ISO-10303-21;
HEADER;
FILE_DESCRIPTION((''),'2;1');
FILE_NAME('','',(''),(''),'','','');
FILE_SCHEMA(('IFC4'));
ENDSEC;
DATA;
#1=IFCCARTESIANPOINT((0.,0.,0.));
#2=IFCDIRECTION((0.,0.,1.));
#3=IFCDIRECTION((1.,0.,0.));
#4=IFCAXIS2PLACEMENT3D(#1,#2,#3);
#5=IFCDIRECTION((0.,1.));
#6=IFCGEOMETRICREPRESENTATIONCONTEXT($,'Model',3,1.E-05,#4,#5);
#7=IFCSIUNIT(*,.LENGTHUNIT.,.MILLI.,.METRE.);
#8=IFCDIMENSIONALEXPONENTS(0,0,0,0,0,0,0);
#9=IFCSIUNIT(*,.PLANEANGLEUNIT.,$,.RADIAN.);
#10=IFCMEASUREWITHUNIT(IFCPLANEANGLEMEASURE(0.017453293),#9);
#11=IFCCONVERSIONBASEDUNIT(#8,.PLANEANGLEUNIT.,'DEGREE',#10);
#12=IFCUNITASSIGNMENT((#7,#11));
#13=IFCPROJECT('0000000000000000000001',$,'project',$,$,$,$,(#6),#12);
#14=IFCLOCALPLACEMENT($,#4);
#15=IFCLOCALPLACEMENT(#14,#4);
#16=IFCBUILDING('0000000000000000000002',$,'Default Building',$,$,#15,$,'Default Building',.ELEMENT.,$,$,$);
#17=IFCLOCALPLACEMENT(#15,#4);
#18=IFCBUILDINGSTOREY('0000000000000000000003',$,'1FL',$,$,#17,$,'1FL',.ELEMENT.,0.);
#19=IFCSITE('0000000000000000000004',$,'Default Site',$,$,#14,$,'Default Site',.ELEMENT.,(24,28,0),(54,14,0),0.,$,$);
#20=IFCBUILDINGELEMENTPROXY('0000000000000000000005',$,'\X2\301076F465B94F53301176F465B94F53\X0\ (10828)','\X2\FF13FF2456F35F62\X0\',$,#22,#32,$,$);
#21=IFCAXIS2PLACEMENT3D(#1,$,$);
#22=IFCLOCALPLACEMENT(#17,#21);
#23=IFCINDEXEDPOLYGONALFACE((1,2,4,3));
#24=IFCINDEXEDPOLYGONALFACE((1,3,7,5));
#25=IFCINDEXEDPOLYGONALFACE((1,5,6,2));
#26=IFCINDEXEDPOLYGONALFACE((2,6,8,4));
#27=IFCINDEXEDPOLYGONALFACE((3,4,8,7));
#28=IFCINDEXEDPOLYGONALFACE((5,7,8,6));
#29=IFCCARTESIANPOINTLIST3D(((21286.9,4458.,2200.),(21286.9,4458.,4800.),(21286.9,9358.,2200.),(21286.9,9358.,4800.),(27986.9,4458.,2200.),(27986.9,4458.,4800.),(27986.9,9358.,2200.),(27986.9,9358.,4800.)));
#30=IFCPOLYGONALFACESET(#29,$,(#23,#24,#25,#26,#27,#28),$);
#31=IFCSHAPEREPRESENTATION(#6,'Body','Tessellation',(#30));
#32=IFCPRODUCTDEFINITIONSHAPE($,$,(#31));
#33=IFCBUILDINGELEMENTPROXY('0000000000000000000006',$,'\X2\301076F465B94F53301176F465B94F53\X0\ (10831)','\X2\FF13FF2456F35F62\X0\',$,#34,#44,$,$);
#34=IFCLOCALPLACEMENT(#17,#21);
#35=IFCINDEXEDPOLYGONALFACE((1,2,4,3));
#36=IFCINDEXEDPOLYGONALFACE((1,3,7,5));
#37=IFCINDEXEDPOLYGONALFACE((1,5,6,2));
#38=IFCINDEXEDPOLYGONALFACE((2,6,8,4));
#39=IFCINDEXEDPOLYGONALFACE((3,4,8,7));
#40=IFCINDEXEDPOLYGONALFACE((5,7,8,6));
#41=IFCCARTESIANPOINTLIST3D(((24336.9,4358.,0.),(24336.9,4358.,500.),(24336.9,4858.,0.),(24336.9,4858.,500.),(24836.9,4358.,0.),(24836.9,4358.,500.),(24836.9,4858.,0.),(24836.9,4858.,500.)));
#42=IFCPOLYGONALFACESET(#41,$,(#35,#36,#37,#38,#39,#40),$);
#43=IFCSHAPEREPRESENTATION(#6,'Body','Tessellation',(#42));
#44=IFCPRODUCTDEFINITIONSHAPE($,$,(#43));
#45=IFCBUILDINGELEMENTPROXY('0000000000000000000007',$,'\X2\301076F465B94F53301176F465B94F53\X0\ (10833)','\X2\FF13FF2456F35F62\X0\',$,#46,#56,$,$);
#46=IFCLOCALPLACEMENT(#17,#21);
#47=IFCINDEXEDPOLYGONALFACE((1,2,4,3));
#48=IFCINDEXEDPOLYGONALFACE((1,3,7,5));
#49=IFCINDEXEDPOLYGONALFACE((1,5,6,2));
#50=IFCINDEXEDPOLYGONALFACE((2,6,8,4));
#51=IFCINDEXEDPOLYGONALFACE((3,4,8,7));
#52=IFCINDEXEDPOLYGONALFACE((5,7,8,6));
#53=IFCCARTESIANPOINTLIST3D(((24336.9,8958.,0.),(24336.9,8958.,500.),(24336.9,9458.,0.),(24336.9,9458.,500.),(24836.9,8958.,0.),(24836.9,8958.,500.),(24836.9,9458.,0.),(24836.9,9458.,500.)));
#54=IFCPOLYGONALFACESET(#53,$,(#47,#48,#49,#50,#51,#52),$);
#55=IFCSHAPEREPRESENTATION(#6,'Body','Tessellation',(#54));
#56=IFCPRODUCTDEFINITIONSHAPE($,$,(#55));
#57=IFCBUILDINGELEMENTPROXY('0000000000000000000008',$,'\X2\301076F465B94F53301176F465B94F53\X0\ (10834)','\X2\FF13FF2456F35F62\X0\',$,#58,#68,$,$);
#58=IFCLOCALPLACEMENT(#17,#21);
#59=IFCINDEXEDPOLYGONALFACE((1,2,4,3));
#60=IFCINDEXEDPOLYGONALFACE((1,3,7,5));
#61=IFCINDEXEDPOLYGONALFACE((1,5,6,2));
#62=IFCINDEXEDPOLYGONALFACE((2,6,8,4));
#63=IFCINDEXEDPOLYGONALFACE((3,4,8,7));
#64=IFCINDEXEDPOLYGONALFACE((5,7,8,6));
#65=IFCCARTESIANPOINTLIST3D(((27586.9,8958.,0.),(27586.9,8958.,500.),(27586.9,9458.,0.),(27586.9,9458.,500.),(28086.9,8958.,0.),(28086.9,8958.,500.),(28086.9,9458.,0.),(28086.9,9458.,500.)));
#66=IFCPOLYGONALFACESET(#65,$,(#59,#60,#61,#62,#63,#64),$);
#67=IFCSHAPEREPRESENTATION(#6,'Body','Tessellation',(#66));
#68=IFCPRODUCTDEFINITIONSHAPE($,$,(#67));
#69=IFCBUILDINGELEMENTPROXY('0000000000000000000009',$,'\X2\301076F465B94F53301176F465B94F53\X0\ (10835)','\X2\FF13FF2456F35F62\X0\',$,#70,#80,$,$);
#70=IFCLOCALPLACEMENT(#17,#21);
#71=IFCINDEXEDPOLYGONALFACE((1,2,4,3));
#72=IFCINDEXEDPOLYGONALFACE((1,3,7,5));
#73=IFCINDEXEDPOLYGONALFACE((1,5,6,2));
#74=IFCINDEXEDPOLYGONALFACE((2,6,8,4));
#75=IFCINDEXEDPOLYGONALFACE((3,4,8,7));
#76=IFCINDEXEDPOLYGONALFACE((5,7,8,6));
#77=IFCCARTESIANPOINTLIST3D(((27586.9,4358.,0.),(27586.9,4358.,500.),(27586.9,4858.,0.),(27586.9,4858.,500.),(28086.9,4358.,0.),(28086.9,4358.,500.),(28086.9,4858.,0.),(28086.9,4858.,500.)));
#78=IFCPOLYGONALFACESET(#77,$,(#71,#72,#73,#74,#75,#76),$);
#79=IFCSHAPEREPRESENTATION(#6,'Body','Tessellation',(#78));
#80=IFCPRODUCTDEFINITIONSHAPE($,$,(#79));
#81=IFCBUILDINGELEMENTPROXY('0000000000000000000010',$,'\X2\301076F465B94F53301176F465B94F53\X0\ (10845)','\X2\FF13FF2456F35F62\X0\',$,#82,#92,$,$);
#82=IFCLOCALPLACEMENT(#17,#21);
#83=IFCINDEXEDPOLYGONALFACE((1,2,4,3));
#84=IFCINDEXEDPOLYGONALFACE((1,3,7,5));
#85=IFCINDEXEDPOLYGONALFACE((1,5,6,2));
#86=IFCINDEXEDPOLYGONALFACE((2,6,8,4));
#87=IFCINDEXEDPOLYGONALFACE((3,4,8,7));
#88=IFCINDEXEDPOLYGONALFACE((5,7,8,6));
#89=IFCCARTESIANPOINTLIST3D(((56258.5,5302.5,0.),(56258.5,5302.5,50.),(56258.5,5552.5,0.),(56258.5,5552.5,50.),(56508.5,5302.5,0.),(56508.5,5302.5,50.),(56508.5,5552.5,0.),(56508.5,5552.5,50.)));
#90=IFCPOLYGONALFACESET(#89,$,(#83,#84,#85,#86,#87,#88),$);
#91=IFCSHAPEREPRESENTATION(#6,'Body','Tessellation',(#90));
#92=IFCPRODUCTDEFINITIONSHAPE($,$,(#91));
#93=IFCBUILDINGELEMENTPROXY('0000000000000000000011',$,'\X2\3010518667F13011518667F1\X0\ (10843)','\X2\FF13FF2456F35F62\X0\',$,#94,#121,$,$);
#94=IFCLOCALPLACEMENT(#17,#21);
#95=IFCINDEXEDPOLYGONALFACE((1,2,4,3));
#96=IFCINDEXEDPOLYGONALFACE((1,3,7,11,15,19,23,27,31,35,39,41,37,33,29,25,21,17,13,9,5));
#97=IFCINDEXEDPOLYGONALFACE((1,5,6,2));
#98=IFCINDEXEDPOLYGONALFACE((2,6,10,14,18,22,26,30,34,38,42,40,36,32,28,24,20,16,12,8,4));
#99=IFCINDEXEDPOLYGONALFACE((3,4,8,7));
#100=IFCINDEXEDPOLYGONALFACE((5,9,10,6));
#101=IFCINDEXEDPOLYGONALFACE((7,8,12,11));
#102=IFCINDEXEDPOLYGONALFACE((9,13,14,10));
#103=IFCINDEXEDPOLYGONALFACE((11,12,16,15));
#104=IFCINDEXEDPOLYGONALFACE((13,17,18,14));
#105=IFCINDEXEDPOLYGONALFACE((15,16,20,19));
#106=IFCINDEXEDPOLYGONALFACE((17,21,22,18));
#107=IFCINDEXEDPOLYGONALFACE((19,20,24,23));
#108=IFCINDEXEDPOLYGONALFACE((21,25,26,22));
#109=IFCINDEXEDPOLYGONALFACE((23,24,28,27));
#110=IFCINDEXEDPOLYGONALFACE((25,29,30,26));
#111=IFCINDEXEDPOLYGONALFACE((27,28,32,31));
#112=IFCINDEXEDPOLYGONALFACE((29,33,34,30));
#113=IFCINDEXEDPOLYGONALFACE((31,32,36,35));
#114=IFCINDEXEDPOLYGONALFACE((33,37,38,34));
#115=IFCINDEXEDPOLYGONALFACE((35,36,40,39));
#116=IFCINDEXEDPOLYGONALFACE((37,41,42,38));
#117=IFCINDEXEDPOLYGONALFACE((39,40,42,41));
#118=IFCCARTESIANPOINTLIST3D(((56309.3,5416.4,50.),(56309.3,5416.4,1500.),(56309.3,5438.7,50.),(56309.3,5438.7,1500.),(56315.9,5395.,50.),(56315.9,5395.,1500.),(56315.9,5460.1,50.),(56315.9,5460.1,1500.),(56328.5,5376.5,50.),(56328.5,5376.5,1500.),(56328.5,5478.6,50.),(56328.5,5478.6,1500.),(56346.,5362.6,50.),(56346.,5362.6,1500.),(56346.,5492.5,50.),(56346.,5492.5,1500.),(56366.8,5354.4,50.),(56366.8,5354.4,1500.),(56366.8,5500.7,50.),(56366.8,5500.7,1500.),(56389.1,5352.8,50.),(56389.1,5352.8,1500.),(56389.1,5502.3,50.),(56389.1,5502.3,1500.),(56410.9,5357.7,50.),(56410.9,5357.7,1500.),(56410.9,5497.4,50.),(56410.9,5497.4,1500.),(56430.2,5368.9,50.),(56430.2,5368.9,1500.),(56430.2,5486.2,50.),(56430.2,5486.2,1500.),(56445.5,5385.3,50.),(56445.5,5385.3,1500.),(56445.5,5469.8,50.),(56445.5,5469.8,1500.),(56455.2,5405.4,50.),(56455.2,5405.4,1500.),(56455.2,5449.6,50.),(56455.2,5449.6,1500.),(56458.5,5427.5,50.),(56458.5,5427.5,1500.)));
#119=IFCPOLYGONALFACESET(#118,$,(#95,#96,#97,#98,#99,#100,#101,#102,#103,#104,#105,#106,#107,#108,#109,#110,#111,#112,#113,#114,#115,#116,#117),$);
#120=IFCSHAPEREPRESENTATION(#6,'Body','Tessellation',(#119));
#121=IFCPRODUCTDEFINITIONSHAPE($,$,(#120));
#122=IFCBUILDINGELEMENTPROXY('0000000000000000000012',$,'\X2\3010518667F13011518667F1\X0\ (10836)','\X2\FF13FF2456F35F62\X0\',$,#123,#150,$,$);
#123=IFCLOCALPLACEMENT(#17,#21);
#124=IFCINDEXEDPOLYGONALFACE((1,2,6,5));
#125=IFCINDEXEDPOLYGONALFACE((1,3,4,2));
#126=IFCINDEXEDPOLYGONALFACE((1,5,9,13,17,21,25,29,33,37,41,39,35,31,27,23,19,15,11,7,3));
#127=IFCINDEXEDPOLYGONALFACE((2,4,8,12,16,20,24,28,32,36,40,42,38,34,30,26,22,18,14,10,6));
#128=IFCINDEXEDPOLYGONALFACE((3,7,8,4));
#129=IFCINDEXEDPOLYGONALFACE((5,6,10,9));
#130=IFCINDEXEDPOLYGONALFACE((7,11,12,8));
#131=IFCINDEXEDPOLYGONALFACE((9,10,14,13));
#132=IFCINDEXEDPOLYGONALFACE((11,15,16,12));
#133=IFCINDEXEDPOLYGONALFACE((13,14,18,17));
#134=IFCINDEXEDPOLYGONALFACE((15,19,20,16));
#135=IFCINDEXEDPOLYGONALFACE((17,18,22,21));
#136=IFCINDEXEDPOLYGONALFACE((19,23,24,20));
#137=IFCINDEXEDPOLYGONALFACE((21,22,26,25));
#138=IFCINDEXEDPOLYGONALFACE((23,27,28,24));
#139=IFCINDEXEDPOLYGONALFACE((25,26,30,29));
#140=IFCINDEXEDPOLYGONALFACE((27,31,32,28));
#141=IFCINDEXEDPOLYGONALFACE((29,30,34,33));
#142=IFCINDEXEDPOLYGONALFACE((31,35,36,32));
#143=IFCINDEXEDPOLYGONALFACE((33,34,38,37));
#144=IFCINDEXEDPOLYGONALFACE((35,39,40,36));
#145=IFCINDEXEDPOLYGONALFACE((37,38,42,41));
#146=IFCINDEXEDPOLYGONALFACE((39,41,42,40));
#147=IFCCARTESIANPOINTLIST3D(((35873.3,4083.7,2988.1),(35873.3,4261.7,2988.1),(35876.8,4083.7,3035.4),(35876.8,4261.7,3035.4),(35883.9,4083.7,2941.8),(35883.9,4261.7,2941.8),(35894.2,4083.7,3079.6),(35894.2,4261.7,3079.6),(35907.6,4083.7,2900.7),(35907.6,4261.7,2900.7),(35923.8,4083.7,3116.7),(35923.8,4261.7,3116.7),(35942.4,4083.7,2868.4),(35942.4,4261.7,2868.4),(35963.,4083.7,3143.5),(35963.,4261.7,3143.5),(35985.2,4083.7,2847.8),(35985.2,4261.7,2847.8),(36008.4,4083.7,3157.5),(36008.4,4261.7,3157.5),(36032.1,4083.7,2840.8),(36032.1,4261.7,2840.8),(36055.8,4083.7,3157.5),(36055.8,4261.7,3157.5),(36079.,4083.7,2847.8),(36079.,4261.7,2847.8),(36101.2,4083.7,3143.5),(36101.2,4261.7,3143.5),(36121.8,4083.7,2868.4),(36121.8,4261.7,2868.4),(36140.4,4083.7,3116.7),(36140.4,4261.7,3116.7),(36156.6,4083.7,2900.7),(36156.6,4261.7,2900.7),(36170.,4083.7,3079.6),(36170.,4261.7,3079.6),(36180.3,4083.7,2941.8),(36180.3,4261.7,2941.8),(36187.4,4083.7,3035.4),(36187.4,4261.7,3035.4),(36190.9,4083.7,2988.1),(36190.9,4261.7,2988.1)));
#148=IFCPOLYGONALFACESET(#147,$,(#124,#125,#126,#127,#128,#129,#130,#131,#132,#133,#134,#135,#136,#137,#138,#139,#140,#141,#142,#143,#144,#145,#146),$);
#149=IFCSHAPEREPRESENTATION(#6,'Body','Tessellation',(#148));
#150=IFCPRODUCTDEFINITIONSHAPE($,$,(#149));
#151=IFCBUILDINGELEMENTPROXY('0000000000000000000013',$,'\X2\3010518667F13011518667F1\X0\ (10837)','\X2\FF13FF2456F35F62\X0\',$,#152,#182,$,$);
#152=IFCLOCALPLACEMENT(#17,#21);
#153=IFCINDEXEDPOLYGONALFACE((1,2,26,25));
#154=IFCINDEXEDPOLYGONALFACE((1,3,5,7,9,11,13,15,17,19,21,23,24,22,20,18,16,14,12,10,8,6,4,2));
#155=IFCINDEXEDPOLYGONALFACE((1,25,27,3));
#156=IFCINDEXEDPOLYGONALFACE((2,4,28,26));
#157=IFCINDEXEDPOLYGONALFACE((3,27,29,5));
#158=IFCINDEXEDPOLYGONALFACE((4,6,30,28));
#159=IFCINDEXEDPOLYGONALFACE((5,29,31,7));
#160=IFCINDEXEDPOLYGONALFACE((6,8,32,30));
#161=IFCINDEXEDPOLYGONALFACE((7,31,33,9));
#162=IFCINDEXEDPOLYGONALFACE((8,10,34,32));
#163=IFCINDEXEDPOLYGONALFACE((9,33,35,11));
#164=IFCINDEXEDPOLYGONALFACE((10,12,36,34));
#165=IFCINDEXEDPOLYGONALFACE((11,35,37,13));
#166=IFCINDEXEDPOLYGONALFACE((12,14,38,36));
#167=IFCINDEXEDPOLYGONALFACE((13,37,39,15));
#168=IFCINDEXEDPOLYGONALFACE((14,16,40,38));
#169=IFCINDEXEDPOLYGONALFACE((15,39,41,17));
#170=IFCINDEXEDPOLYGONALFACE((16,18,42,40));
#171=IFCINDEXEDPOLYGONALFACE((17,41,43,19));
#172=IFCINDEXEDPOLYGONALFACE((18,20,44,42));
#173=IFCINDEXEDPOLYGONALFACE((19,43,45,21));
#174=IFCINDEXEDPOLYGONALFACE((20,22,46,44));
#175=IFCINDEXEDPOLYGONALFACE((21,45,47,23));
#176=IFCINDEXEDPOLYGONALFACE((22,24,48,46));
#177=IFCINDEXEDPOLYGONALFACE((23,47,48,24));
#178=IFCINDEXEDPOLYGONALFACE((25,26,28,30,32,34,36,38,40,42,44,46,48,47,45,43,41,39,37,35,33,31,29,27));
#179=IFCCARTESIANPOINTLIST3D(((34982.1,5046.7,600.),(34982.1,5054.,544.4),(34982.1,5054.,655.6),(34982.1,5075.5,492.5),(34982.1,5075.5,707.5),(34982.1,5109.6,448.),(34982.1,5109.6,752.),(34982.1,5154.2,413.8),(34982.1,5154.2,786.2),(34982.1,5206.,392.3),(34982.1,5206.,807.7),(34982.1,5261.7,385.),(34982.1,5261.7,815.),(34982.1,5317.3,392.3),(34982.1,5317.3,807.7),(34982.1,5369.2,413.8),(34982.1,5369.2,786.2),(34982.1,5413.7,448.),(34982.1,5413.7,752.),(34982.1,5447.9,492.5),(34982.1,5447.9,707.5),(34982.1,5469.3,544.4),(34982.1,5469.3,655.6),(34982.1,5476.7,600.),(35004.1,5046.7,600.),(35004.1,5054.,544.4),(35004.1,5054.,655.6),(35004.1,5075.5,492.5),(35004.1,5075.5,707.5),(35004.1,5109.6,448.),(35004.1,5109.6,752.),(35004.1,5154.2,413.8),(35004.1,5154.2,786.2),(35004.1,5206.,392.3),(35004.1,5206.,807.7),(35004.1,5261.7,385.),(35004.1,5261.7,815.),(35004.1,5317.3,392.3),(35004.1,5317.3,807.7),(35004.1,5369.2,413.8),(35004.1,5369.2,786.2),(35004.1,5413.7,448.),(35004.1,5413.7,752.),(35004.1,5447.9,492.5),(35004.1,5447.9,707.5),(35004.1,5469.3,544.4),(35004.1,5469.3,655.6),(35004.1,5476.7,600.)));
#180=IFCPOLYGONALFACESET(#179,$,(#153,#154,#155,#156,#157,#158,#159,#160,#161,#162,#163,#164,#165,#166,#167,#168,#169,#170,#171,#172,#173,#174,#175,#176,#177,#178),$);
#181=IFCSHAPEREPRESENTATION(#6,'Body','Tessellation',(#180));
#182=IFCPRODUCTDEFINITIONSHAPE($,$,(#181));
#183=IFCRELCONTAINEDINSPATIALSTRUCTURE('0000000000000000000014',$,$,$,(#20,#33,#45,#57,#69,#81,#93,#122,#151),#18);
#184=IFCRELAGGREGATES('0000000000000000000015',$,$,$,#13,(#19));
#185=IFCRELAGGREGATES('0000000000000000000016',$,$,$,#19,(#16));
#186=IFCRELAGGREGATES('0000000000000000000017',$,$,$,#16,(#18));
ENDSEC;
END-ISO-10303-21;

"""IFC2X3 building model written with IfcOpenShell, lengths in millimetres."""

from ifc_helpers import new_model, entity, si_unit, converted_unit, direction, frame, origin_with_axes, origin_2d_with_axis, place, context, project, spatial, rectangle, circle, extrude, source, transform, mapped, element, save


model = new_model("IFC2X3")

# Units and contexts
model_context = context("Model", 3, precision=1e-05, world=origin_with_axes(), true_north=direction((0.0, 1.0)))
ifc_project = project(units=[si_unit("LENGTHUNIT", "METRE", prefix="MILLI"), converted_unit("PLANEANGLEUNIT", "DEGREE", entity("IfcPlaneAngleMeasure", 0.017453293), si_unit("PLANEANGLEUNIT", "RADIAN"), dimensions=[0, 0, 0, 0, 0, 0, 0])], contexts=[model_context])

# Site, building, storey
site_placement = place(None, origin_with_axes())
site = spatial("IfcSite", under=ifc_project, at=site_placement, Name="Default Site", LongName="Default Site", CompositionType="ELEMENT", RefLatitude=(24, 28, 0), RefLongitude=(54, 14, 0), RefElevation=0.0)
building_placement = place(site_placement, origin_with_axes())
building = spatial("IfcBuilding", under=site, at=building_placement, Name="Default Building", LongName="Default Building", CompositionType="ELEMENT")
storey_placement = place(building_placement, origin_with_axes())
storey = spatial("IfcBuildingStorey", under=building, at=storey_placement, Name="1FL", LongName="1FL", CompositionType="ELEMENT", Elevation=0.0)

# Building element proxies
shared_shape_1 = source(origin_with_axes(), model_context, "Body", "SweptSolid", [
    extrude(rectangle(XDim=6700.0, YDim=4900.0, at=origin_2d_with_axis()), origin_with_axes(), (0.0, 0.0, 1.0), 2600.0),
])
proxy_1_placement = place(storey_placement, frame((24636.9, 6908.0, 2200.0), z_axis=(0.0, 0.0, 1.0), x_axis=(1.0, 0.0, 0.0)))
element("IfcBuildingElementProxy", 1, at=proxy_1_placement, inside=storey, Name="【直方体】直方体 (10828)", Description="３Ｄ図形", context=model_context, shape_type="MappedRepresentation", body=[
    mapped(shared_shape_1, transform((0.0, 0.0, 0.0))),
])
shared_shape_2 = source(origin_with_axes(), model_context, "Body", "SweptSolid", [
    extrude(rectangle(XDim=500.0, YDim=500.0, at=origin_2d_with_axis()), origin_with_axes(), (0.0, 0.0, 1.0), 500.0),
])
proxy_2_placement = place(storey_placement, frame((24586.9, 4608.0, 0.0), z_axis=(0.0, 0.0, 1.0), x_axis=(1.0, 0.0, 0.0)))
element("IfcBuildingElementProxy", 2, at=proxy_2_placement, inside=storey, Name="【直方体】直方体 (10831)", Description="３Ｄ図形", context=model_context, shape_type="MappedRepresentation", body=[
    mapped(shared_shape_2, transform((0.0, 0.0, 0.0))),
])
shared_shape_3 = source(origin_with_axes(), model_context, "Body", "SweptSolid", [
    extrude(rectangle(XDim=500.0, YDim=500.0, at=origin_2d_with_axis()), origin_with_axes(), (0.0, 0.0, 1.0), 500.0),
])
proxy_3_placement = place(storey_placement, frame((24586.9, 9208.0, 0.0), z_axis=(0.0, 0.0, 1.0), x_axis=(1.0, 0.0, 0.0)))
element("IfcBuildingElementProxy", 3, at=proxy_3_placement, inside=storey, Name="【直方体】直方体 (10833)", Description="３Ｄ図形", context=model_context, shape_type="MappedRepresentation", body=[
    mapped(shared_shape_3, transform((0.0, 0.0, 0.0))),
])
shared_shape_4 = source(origin_with_axes(), model_context, "Body", "SweptSolid", [
    extrude(rectangle(XDim=500.0, YDim=500.0, at=origin_2d_with_axis()), origin_with_axes(), (0.0, 0.0, 1.0), 500.0),
])
proxy_4_placement = place(storey_placement, frame((27836.9, 9208.0, 0.0), z_axis=(0.0, 0.0, 1.0), x_axis=(1.0, 0.0, 0.0)))
element("IfcBuildingElementProxy", 4, at=proxy_4_placement, inside=storey, Name="【直方体】直方体 (10834)", Description="３Ｄ図形", context=model_context, shape_type="MappedRepresentation", body=[
    mapped(shared_shape_4, transform((0.0, 0.0, 0.0))),
])
shared_shape_5 = source(origin_with_axes(), model_context, "Body", "SweptSolid", [
    extrude(rectangle(XDim=500.0, YDim=500.0, at=origin_2d_with_axis()), origin_with_axes(), (0.0, 0.0, 1.0), 500.0),
])
proxy_5_placement = place(storey_placement, frame((27836.9, 4608.0, 0.0), z_axis=(0.0, 0.0, 1.0), x_axis=(1.0, 0.0, 0.0)))
element("IfcBuildingElementProxy", 5, at=proxy_5_placement, inside=storey, Name="【直方体】直方体 (10835)", Description="３Ｄ図形", context=model_context, shape_type="MappedRepresentation", body=[
    mapped(shared_shape_5, transform((0.0, 0.0, 0.0))),
])
shared_shape_6 = source(origin_with_axes(), model_context, "Body", "SweptSolid", [
    extrude(rectangle(XDim=250.0, YDim=250.0, at=origin_2d_with_axis()), origin_with_axes(), (0.0, 0.0, 1.0), 50.0),
])
proxy_6_placement = place(storey_placement, frame((56383.5, 5427.5, 0.0), z_axis=(0.0, 0.0, 1.0), x_axis=(1.0, 0.0, 0.0)))
element("IfcBuildingElementProxy", 6, at=proxy_6_placement, inside=storey, Name="【直方体】直方体 (10845)", Description="３Ｄ図形", context=model_context, shape_type="MappedRepresentation", body=[
    mapped(shared_shape_6, transform((0.0, 0.0, 0.0))),
])
shared_shape_7 = source(origin_with_axes(), model_context, "Body", "SweptSolid", [
    extrude(circle(Radius=75.0, at=origin_2d_with_axis()), origin_with_axes(), (0.0, 0.0, 1.0), 1450.0),
])
proxy_7_placement = place(storey_placement, frame((56383.5, 5427.5, 50.0), z_axis=(0.0, 0.0, 1.0), x_axis=(1.0, 0.0, 0.0)))
element("IfcBuildingElementProxy", 7, at=proxy_7_placement, inside=storey, Name="【円柱】円柱 (10843)", Description="３Ｄ図形", context=model_context, shape_type="MappedRepresentation", body=[
    mapped(shared_shape_7, transform((0.0, 0.0, 0.0))),
])
shared_shape_8 = source(origin_with_axes(), model_context, "Body", "SweptSolid", [
    extrude(circle(Radius=159.2, at=origin_2d_with_axis()), frame((0.0, 0.0, 0.0), z_axis=(0.0, 0.0, 1.0), x_axis=(1.0, 0.0, 0.0)), (0.0, 0.0, 1.0), 178.0),
])
proxy_8_placement = place(storey_placement, frame((36032.1, 4261.7, 3000.0), z_axis=(0.0, -1.0, 0.0), x_axis=(0.0, 0.0, -1.0)))
element("IfcBuildingElementProxy", 8, at=proxy_8_placement, inside=storey, Name="【円柱】円柱 (10836)", Description="３Ｄ図形", context=model_context, shape_type="MappedRepresentation", body=[
    mapped(shared_shape_8, transform((0.0, 0.0, 0.0))),
])
shared_shape_9 = source(origin_with_axes(), model_context, "Body", "SweptSolid", [
    extrude(circle(Radius=215.0, at=origin_2d_with_axis()), frame((0.0, 0.0, 0.0), z_axis=(0.0, 0.0, 1.0), x_axis=(1.0, 0.0, 0.0)), (0.0, 0.0, 1.0), 22.0),
])
proxy_9_placement = place(storey_placement, frame((34982.1, 5261.7, 600.0), z_axis=(1.0, 0.0, 0.0), x_axis=(0.0, 0.0, -1.0)))
element("IfcBuildingElementProxy", 9, at=proxy_9_placement, inside=storey, Name="【円柱】円柱 (10837)", Description="３Ｄ図形", context=model_context, shape_type="MappedRepresentation", body=[
    mapped(shared_shape_9, transform((0.0, 0.0, 0.0))),
])

save(model, "model.ifc")
